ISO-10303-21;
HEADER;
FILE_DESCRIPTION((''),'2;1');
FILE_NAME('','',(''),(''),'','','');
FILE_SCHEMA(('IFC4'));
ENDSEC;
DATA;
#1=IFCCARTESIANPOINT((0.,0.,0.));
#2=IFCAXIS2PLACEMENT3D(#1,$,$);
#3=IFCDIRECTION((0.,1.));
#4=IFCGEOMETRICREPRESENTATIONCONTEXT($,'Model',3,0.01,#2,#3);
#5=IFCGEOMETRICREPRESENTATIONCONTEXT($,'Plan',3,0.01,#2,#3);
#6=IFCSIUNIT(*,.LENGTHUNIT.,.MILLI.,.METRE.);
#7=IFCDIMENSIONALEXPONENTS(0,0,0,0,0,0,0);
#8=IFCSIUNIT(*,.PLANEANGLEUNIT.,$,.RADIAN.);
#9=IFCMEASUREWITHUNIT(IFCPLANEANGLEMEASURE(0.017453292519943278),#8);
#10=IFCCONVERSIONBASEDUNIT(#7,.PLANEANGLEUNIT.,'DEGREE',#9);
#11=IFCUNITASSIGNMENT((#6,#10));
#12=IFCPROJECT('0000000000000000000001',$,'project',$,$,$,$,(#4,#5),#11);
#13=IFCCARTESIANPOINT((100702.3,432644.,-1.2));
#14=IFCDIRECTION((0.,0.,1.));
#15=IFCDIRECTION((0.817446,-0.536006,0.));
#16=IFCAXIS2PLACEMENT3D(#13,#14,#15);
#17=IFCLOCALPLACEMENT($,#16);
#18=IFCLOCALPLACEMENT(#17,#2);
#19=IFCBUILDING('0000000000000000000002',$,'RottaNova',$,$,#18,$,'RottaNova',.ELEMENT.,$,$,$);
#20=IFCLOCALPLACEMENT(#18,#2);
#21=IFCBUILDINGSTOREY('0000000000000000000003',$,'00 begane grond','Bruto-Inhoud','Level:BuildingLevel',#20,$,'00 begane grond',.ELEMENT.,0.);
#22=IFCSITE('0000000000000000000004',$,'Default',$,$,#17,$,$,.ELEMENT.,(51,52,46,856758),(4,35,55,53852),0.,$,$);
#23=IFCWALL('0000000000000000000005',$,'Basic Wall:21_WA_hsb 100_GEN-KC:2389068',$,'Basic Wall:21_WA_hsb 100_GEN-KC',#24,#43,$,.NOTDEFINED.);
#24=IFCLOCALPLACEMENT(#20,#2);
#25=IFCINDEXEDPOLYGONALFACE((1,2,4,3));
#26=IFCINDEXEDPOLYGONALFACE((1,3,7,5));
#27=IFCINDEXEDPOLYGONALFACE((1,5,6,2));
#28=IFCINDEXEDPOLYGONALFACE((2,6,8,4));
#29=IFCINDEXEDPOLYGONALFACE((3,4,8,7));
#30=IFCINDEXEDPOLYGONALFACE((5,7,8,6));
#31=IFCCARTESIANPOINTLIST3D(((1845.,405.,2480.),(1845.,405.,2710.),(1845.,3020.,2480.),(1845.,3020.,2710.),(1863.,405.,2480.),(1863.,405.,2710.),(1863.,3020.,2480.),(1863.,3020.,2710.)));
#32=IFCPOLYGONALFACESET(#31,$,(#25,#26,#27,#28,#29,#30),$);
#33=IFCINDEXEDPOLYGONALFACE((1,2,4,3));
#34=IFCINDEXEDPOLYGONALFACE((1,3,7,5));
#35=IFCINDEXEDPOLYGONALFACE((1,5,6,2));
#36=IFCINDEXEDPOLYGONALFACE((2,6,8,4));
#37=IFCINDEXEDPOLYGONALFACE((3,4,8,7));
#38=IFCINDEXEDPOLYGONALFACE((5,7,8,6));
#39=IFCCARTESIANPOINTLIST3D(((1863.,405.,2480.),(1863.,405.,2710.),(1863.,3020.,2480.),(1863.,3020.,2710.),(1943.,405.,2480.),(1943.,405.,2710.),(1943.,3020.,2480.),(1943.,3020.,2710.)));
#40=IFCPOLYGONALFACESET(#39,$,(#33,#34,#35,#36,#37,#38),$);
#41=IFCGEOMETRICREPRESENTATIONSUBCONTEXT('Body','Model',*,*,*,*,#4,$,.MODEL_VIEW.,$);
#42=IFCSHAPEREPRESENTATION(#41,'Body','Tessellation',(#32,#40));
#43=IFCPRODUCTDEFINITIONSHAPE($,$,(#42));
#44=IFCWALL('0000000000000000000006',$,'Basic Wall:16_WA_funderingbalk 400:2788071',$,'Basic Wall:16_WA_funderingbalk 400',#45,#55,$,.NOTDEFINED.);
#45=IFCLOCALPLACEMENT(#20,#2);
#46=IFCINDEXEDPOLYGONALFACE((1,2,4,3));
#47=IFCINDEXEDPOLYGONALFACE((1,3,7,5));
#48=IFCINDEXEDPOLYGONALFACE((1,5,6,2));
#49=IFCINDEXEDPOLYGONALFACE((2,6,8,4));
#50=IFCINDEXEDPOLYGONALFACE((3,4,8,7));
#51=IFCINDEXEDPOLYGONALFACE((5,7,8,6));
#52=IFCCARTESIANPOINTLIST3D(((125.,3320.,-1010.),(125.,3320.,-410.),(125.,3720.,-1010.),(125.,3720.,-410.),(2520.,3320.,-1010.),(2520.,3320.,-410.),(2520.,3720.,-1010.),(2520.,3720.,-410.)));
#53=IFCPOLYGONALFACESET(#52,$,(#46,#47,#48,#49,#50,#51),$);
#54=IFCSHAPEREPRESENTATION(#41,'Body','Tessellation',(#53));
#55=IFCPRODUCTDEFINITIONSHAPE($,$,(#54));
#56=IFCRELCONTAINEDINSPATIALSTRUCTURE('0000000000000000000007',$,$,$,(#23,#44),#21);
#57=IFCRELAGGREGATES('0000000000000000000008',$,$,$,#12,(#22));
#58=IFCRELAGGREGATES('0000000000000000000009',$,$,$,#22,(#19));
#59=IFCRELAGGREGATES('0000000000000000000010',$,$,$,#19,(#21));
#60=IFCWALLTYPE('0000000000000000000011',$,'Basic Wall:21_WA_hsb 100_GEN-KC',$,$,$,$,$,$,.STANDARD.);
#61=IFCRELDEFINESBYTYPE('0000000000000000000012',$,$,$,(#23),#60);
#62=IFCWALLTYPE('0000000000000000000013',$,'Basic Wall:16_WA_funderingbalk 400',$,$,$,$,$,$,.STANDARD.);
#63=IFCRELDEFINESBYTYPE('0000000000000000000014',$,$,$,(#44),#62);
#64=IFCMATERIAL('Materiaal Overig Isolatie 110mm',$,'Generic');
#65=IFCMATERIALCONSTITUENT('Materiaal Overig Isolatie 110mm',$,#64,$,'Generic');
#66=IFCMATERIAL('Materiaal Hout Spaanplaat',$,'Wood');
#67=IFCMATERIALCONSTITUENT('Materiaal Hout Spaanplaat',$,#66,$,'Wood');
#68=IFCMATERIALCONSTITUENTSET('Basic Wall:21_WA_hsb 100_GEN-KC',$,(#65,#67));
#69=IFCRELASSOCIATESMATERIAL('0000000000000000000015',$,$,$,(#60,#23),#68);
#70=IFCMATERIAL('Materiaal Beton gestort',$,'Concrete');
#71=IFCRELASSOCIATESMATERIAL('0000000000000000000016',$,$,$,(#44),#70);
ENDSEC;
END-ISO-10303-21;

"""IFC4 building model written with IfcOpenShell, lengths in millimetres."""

from ifc_helpers import new_model, entity, si_unit, converted_unit, direction, frame, origin, place, context, subcontext, project, spatial, indexed_curve, outline, extrude, material, constituent, constituent_set, type_object, element, save


model = new_model("IFC4")

# Units and contexts
model_context = context("Model", 3, precision=0.01, world=origin(), true_north=direction((0.0, 1.0)))
plan_context = context("Plan", 3, precision=0.01, world=origin(), true_north=direction((0.0, 1.0)))
body_context = subcontext(model_context, "Body", "Model", "MODEL_VIEW")
ifc_project = project(units=[si_unit("LENGTHUNIT", "METRE", prefix="MILLI"), converted_unit("PLANEANGLEUNIT", "DEGREE", entity("IfcPlaneAngleMeasure", 0.017453292519943278), si_unit("PLANEANGLEUNIT", "RADIAN"), dimensions=[0, 0, 0, 0, 0, 0, 0])], contexts=[model_context, plan_context])

# Site, building, storey
site_placement = place(None, frame((100702.3, 432644.0, -1.2), z_axis=(0.0, 0.0, 1.0), x_axis=(0.817446, -0.536006, 0.0)))
site = spatial("IfcSite", under=ifc_project, at=site_placement, Name="Default", CompositionType="ELEMENT", RefLatitude=(51, 52, 46, 856758), RefLongitude=(4, 35, 55, 53852), RefElevation=0.0)
building_placement = place(site_placement, origin())
building = spatial("IfcBuilding", under=site, at=building_placement, Name="RottaNova", LongName="RottaNova", CompositionType="ELEMENT")
storey_placement = place(building_placement, origin())
storey = spatial("IfcBuildingStorey", under=building, at=storey_placement, Name="00 begane grond", Description="Bruto-Inhoud", ObjectType="Level:BuildingLevel", LongName="00 begane grond", CompositionType="ELEMENT", Elevation=0.0)

# Walls
ifc_material_1 = material(Name="Materiaal Overig Isolatie 110mm", Category="Generic")
ifc_constituent_1 = constituent(ifc_material_1, Name="Materiaal Overig Isolatie 110mm", Category="Generic")
ifc_material_2 = material(Name="Materiaal Hout Spaanplaat", Category="Wood")
ifc_constituent_2 = constituent(ifc_material_2, Name="Materiaal Hout Spaanplaat", Category="Wood")
ifc_constituent_set = constituent_set(constituents=[ifc_constituent_1, ifc_constituent_2], Name="Basic Wall:21_WA_hsb 100_GEN-KC")
wall_type_1 = type_object("IfcWallType", Name="Basic Wall:21_WA_hsb 100_GEN-KC", PredefinedType="STANDARD", material=ifc_constituent_set)
wall_1_placement = place(storey_placement, frame((1894.0, 3020.0, 2480.0), z_axis=(0.0, 0.0, 1.0), x_axis=(0.0, -1.0, 0.0)))
element("IfcWall", 1, at=wall_1_placement, inside=storey, type_object=wall_type_1, material=ifc_constituent_set, Name="Basic Wall:21_WA_hsb 100_GEN-KC:2389068", ObjectType="Basic Wall:21_WA_hsb 100_GEN-KC", PredefinedType="NOTDEFINED", context=body_context, shape_type="SweptSolid", body=[
    extrude(outline(indexed_curve([(-9.0, -1307.5), (9.0, -1307.5), (9.0, 1307.5), (-9.0, 1307.5), (-9.0, -1307.5)], self_intersect=False)), frame((1307.5, -40.0, 0.0), z_axis=(0.0, 0.0, 1.0), x_axis=(0.0, 1.0, 0.0)), (0.0, 0.0, 1.0), 230.0),
    extrude(outline(indexed_curve([(-40.0, -1307.5), (40.0, -1307.5), (40.0, 1307.5), (-40.0, 1307.5), (-40.0, -1307.5)], self_intersect=False)), frame((1307.5, 9.0, 0.0), z_axis=(0.0, 0.0, 1.0), x_axis=(0.0, -1.0, 0.0)), (0.0, 0.0, 1.0), 230.0),
])
ifc_material_3 = material(Name="Materiaal Beton gestort", Category="Concrete")
wall_type_2 = type_object("IfcWallType", Name="Basic Wall:16_WA_funderingbalk 400", PredefinedType="STANDARD")
wall_2_placement = place(storey_placement, frame((125.0, 3520.0, -1010.0)))
element("IfcWall", 2, at=wall_2_placement, inside=storey, type_object=wall_type_2, material=ifc_material_3, Name="Basic Wall:16_WA_funderingbalk 400:2788071", ObjectType="Basic Wall:16_WA_funderingbalk 400", PredefinedType="NOTDEFINED", context=body_context, shape_type="SweptSolid", body=[
    extrude(outline(indexed_curve([(2395.0, 200.0), (0.0, 200.0), (0.0, -200.0), (2395.0, -200.0), (2395.0, 200.0)], self_intersect=False)), origin(), (0.0, 0.0, 1.0), 600.0),
])

save(model, "model.ifc")
